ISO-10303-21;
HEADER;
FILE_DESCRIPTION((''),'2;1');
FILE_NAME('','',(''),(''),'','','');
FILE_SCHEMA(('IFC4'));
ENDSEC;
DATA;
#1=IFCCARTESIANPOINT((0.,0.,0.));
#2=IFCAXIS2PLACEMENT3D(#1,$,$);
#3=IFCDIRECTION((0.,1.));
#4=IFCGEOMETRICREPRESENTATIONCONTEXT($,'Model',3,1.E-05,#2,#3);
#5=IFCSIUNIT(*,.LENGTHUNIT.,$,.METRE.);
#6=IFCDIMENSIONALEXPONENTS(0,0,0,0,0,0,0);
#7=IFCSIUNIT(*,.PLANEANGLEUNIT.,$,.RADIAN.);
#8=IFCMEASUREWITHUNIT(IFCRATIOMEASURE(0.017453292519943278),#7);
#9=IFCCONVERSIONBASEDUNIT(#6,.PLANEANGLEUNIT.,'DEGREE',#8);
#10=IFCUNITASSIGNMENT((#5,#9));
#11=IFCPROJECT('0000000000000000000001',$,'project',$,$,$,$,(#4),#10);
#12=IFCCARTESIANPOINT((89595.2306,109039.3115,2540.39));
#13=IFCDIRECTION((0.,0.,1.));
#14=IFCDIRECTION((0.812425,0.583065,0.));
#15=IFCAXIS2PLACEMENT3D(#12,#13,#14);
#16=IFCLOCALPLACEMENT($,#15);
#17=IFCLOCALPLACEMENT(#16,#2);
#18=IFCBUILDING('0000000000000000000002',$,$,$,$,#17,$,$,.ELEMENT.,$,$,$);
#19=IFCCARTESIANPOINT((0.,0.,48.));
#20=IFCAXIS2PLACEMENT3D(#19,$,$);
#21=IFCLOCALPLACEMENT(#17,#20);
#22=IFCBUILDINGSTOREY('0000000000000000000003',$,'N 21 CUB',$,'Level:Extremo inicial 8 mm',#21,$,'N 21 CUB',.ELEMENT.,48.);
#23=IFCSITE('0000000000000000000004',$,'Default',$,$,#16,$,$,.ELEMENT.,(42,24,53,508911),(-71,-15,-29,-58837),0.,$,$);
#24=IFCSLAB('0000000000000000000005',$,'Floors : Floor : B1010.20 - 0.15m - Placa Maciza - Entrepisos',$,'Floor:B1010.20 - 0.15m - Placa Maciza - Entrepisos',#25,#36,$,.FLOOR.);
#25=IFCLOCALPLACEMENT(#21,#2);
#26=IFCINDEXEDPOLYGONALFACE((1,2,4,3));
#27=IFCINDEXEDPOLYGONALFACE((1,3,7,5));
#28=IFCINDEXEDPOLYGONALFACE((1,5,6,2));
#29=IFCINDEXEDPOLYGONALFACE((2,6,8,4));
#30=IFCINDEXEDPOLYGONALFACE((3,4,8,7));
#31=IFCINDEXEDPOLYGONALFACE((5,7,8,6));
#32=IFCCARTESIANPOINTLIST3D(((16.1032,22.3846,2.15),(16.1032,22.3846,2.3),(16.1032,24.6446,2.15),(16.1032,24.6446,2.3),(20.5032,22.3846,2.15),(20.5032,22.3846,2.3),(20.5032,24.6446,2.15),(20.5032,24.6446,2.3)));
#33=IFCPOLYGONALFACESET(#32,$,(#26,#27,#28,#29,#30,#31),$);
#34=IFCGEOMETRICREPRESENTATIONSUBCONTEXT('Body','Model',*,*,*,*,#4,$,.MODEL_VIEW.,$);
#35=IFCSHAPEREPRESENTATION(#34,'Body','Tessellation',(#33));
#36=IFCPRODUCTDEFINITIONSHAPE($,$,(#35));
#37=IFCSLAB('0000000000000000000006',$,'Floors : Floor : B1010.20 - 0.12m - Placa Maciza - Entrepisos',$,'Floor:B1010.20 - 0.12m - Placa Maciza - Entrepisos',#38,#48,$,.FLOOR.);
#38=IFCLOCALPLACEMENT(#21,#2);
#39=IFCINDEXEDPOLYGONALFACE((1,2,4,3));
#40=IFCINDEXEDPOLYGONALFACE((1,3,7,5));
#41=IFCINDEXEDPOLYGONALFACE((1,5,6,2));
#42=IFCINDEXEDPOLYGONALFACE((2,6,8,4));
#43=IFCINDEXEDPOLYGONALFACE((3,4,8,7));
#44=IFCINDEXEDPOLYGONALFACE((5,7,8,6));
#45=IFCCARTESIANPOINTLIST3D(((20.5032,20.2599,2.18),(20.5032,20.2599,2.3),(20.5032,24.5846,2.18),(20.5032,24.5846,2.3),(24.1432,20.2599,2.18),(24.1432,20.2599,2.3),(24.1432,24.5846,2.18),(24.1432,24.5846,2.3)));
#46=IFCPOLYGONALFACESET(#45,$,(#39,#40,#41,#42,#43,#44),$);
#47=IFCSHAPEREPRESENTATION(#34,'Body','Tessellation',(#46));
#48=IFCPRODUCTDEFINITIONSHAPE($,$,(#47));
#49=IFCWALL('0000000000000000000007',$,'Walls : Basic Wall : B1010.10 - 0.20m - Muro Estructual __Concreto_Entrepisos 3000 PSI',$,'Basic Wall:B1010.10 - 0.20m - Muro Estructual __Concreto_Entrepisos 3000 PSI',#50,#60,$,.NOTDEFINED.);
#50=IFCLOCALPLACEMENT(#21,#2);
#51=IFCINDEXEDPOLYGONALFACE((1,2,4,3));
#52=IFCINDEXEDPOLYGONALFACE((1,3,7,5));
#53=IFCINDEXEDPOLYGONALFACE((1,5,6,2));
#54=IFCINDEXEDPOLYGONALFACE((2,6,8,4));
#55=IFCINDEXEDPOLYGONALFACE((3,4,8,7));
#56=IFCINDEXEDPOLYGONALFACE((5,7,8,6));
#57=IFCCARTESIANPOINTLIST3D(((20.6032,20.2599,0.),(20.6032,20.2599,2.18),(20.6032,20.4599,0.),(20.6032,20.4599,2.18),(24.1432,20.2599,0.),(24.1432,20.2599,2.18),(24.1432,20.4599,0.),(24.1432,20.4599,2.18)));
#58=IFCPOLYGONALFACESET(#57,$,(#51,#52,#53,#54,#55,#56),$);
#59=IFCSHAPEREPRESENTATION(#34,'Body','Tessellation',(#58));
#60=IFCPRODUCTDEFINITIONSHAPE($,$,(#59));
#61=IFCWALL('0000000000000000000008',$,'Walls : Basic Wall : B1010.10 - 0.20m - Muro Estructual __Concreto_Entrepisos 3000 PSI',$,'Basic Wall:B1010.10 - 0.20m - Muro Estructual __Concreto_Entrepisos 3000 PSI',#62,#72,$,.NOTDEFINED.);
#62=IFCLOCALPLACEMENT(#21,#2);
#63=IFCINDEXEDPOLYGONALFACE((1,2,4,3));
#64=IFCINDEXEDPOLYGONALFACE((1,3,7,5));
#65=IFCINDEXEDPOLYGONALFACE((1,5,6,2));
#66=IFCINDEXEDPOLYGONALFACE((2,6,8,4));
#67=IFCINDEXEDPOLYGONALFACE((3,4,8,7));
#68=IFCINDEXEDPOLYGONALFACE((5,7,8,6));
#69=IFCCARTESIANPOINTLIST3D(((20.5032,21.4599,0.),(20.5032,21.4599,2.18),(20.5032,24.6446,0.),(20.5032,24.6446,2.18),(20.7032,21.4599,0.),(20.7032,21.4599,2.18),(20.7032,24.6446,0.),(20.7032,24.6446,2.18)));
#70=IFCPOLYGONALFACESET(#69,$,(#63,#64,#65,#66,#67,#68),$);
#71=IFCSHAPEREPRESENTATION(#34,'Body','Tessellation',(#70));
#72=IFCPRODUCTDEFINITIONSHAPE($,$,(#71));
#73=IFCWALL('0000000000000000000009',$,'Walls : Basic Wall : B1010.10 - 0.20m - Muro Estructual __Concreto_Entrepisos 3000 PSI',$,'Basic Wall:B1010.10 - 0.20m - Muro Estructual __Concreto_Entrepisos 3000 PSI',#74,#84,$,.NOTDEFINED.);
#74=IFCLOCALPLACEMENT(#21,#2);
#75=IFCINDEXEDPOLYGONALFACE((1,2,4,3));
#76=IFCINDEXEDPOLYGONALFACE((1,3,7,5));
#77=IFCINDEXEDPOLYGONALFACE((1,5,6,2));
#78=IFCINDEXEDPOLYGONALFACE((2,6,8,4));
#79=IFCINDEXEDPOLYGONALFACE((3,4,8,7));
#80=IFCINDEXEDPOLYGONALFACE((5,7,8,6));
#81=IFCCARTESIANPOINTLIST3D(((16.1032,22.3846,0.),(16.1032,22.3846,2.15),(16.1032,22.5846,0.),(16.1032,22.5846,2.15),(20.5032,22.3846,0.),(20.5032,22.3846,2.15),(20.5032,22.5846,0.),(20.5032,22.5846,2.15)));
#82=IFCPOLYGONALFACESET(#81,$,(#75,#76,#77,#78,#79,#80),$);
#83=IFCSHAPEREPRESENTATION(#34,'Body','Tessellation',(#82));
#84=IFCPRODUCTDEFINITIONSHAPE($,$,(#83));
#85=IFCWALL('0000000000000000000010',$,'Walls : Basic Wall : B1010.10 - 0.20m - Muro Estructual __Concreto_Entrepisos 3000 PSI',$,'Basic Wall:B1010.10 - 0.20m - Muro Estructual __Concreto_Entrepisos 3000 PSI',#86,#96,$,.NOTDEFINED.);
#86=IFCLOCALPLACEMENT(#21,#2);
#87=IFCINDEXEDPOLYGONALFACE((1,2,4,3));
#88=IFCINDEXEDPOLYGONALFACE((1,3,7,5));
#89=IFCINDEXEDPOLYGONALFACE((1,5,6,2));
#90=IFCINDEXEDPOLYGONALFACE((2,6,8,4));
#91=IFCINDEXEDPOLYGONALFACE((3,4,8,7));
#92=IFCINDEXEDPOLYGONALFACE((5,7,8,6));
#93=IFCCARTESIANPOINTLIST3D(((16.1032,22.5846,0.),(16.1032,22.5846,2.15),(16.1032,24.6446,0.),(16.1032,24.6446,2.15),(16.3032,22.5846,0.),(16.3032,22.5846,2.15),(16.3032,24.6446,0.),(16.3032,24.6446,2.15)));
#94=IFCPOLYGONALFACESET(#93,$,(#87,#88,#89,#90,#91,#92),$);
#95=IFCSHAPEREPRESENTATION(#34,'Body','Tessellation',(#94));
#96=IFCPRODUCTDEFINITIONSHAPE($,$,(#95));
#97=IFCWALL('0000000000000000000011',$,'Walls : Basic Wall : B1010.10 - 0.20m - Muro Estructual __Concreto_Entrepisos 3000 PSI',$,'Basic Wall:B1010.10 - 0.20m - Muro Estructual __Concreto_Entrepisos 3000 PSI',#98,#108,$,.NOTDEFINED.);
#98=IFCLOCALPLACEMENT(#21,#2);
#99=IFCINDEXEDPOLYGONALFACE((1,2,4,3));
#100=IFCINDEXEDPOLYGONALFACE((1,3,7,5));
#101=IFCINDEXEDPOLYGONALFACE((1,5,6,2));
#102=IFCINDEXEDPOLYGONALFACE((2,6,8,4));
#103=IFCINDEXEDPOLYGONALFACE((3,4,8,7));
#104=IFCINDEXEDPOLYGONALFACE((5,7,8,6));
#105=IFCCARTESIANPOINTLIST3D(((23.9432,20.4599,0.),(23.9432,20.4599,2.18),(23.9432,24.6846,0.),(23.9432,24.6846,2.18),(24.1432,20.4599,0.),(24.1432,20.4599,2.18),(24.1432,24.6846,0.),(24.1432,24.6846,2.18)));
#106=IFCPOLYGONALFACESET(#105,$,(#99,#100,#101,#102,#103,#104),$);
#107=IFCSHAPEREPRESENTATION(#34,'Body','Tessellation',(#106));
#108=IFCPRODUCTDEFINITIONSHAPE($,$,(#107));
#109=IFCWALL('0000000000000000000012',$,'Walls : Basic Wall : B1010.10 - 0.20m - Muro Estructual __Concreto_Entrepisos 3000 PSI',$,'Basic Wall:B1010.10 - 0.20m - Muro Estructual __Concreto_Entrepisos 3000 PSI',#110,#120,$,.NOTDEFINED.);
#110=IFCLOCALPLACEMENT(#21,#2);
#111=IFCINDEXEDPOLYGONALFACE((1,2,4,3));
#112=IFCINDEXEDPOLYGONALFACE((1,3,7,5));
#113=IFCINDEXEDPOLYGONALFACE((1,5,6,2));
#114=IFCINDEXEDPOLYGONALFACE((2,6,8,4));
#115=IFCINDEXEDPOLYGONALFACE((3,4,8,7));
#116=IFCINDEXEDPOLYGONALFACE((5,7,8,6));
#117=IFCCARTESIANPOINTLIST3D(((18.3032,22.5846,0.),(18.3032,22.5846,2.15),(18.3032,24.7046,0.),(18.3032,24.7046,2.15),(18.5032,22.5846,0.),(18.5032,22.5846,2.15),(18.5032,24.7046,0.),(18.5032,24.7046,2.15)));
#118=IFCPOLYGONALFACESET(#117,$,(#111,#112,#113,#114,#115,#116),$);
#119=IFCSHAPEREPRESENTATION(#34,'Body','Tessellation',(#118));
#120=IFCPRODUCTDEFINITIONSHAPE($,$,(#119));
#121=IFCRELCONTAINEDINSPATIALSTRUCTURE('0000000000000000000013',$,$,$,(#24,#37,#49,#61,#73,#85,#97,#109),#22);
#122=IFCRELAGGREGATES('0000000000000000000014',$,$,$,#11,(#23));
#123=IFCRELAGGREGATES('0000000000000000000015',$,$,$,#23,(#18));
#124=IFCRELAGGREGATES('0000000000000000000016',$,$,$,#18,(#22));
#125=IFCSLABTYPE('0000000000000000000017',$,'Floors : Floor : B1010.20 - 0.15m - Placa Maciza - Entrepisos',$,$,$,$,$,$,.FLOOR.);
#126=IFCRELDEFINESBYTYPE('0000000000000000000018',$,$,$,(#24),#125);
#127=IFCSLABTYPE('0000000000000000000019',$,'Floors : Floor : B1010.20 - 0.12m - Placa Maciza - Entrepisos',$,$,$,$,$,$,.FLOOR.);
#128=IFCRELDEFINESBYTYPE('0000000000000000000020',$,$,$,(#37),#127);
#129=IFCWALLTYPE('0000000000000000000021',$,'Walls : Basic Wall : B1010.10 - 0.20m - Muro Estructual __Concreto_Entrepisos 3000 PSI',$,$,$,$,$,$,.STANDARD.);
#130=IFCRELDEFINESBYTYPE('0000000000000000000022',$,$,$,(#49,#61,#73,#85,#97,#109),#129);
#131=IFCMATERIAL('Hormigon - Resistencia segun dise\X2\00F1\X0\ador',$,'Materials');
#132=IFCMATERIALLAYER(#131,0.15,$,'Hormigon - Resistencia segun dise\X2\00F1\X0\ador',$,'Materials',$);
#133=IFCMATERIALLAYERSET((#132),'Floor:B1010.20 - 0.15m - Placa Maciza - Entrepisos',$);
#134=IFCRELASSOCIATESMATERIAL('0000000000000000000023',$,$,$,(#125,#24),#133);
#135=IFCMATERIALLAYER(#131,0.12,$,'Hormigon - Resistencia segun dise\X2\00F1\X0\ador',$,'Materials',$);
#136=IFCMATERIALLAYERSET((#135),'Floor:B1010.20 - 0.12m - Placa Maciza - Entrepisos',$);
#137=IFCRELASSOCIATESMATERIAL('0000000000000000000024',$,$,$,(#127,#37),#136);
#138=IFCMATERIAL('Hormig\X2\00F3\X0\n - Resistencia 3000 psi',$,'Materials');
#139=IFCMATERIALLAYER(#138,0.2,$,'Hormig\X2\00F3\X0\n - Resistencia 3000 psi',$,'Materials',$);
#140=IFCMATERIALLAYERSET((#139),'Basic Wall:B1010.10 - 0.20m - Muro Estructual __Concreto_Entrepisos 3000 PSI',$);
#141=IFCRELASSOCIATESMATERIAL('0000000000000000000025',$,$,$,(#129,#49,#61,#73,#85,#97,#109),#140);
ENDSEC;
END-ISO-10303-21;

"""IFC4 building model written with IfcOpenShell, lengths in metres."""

from ifc_helpers import new_model, entity, si_unit, converted_unit, direction, frame, frame_2d, origin, origin_2d_with_axis, place, context, subcontext, project, spatial, rectangle, extrude, material, layer, layer_set, layer_usage, type_object, element, save


model = new_model("IFC4")

# Units and contexts
model_context = context("Model", 3, precision=1e-05, world=origin(), true_north=direction((0.0, 1.0)))
body_context = subcontext(model_context, "Body", "Model", "MODEL_VIEW")
ifc_project = project(units=[si_unit("LENGTHUNIT", "METRE"), converted_unit("PLANEANGLEUNIT", "DEGREE", entity("IfcRatioMeasure", 0.017453292519943278), si_unit("PLANEANGLEUNIT", "RADIAN"), dimensions=[0, 0, 0, 0, 0, 0, 0])], contexts=[model_context])

# Site, building, storey
site_placement = place(None, frame((89595.2306, 109039.3115, 2540.39), z_axis=(0.0, 0.0, 1.0), x_axis=(0.812425, 0.583065, 0.0)))
site = spatial("IfcSite", under=ifc_project, at=site_placement, Name="Default", CompositionType="ELEMENT", RefLatitude=(42, 24, 53, 508911), RefLongitude=(-71, -15, -29, -58837), RefElevation=0.0)
building_placement = place(site_placement, origin())
building = spatial("IfcBuilding", under=site, at=building_placement, CompositionType="ELEMENT")
storey_placement = place(building_placement, frame((0.0, 0.0, 48.0)))
storey = spatial("IfcBuildingStorey", under=building, at=storey_placement, Name="N 21 CUB", ObjectType="Level:Extremo inicial 8 mm", LongName="N 21 CUB", CompositionType="ELEMENT", Elevation=48.0)

# Shared definitions
ifc_material_1 = material(Name="Hormigon - Resistencia segun diseñador", Category="Materials")
ifc_layer_1 = layer(ifc_material_1, 0.12, Name="Hormigon - Resistencia segun diseñador", Category="Materials")
ifc_layer_set_1 = layer_set([ifc_layer_1], Name="Floor:B1010.20 - 0.12m - Placa Maciza - Entrepisos")

# Slabs
ifc_layer_2 = layer(ifc_material_1, 0.15, Name="Hormigon - Resistencia segun diseñador", Category="Materials")
ifc_layer_set_2 = layer_set([ifc_layer_2], Name="Floor:B1010.20 - 0.15m - Placa Maciza - Entrepisos")
ifc_layer_usage_1 = layer_usage(ifc_layer_set_2, "AXIS3", "POSITIVE", 0.0)
slab_type_1 = type_object("IfcSlabType", Name="Floors : Floor : B1010.20 - 0.15m - Placa Maciza - Entrepisos", PredefinedType="FLOOR", material=ifc_layer_set_2)
slab_1_placement = place(storey_placement, origin())
element("IfcSlab", 1, at=slab_1_placement, inside=storey, type_object=slab_type_1, material=ifc_layer_usage_1, Name="Floors : Floor : B1010.20 - 0.15m - Placa Maciza - Entrepisos", ObjectType="Floor:B1010.20 - 0.15m - Placa Maciza - Entrepisos", PredefinedType="FLOOR", context=body_context, shape_type="SweptSolid", body=[
    extrude(rectangle(XDim=2.26, YDim=4.4, at=origin_2d_with_axis()), frame((18.3032, 23.5146, 2.3), z_axis=(0.0, 0.0, -1.0), x_axis=(0.0, 1.0, 0.0)), (0.0, 0.0, 1.0), 0.15),
])
ifc_layer_usage_2 = layer_usage(ifc_layer_set_1, "AXIS3", "POSITIVE", 0.0)
slab_type_2 = type_object("IfcSlabType", Name="Floors : Floor : B1010.20 - 0.12m - Placa Maciza - Entrepisos", PredefinedType="FLOOR", material=ifc_layer_set_1)
slab_2_placement = place(storey_placement, origin())
element("IfcSlab", 2, at=slab_2_placement, inside=storey, type_object=slab_type_2, material=ifc_layer_usage_2, Name="Floors : Floor : B1010.20 - 0.12m - Placa Maciza - Entrepisos", ObjectType="Floor:B1010.20 - 0.12m - Placa Maciza - Entrepisos", PredefinedType="FLOOR", context=body_context, shape_type="SweptSolid", body=[
    extrude(rectangle(XDim=4.3247, YDim=3.64, at=frame_2d((0.0, 0.0), x_axis=(1.0, 0.0))), frame((22.3232, 22.4223, 2.3), z_axis=(0.0, 0.0, -1.0), x_axis=(0.0, 1.0, 0.0)), (0.0, 0.0, 1.0), 0.12),
])

# Walls
ifc_material_2 = material(Name="Hormigón - Resistencia 3000 psi", Category="Materials")
ifc_layer_3 = layer(ifc_material_2, 0.2, Name="Hormigón - Resistencia 3000 psi", Category="Materials")
ifc_layer_set_3 = layer_set([ifc_layer_3], Name="Basic Wall:B1010.10 - 0.20m - Muro Estructual __Concreto_Entrepisos 3000 PSI")
ifc_layer_usage_3 = layer_usage(ifc_layer_set_3, "AXIS2", "POSITIVE", -0.1)
wall_type = type_object("IfcWallType", Name="Walls : Basic Wall : B1010.10 - 0.20m - Muro Estructual __Concreto_Entrepisos 3000 PSI", PredefinedType="STANDARD", material=ifc_layer_set_3)
wall_1_placement = place(storey_placement, frame((20.6032, 20.3599, 0.0)))
element("IfcWall", 3, at=wall_1_placement, inside=storey, type_object=wall_type, material=ifc_layer_usage_3, Name="Walls : Basic Wall : B1010.10 - 0.20m - Muro Estructual __Concreto_Entrepisos 3000 PSI", ObjectType="Basic Wall:B1010.10 - 0.20m - Muro Estructual __Concreto_Entrepisos 3000 PSI", PredefinedType="NOTDEFINED", context=body_context, shape_type="SweptSolid", body=[
    extrude(rectangle(XDim=3.54, YDim=0.2, at=frame_2d((1.77, 0.0), x_axis=(-1.0, 0.0))), origin(), (0.0, 0.0, 1.0), 2.18),
])
ifc_layer_usage_4 = layer_usage(ifc_layer_set_3, "AXIS2", "POSITIVE", -0.1)
wall_2_placement = place(storey_placement, frame((20.6032, 24.6446, 0.0), z_axis=(0.0, 0.0, 1.0), x_axis=(0.0, -1.0, 0.0)))
element("IfcWall", 4, at=wall_2_placement, inside=storey, type_object=wall_type, material=ifc_layer_usage_4, Name="Walls : Basic Wall : B1010.10 - 0.20m - Muro Estructual __Concreto_Entrepisos 3000 PSI", ObjectType="Basic Wall:B1010.10 - 0.20m - Muro Estructual __Concreto_Entrepisos 3000 PSI", PredefinedType="NOTDEFINED", context=body_context, shape_type="SweptSolid", body=[
    extrude(rectangle(XDim=3.1847, YDim=0.2, at=frame_2d((1.5924, 0.0), x_axis=(-1.0, 0.0))), origin(), (0.0, 0.0, 1.0), 2.18),
])
ifc_layer_usage_5 = layer_usage(ifc_layer_set_3, "AXIS2", "POSITIVE", -0.1)
wall_3_placement = place(storey_placement, frame((20.5032, 22.4846, 0.0), z_axis=(0.0, 0.0, 1.0), x_axis=(-1.0, 0.0, 0.0)))
element("IfcWall", 5, at=wall_3_placement, inside=storey, type_object=wall_type, material=ifc_layer_usage_5, Name="Walls : Basic Wall : B1010.10 - 0.20m - Muro Estructual __Concreto_Entrepisos 3000 PSI", ObjectType="Basic Wall:B1010.10 - 0.20m - Muro Estructual __Concreto_Entrepisos 3000 PSI", PredefinedType="NOTDEFINED", context=body_context, shape_type="SweptSolid", body=[
    extrude(rectangle(XDim=4.4, YDim=0.2, at=frame_2d((2.2, 0.0), x_axis=(-1.0, 0.0))), origin(), (0.0, 0.0, 1.0), 2.15),
])
ifc_layer_usage_6 = layer_usage(ifc_layer_set_3, "AXIS2", "POSITIVE", -0.1)
wall_4_placement = place(storey_placement, frame((16.2032, 22.5846, 0.0), z_axis=(0.0, 0.0, 1.0), x_axis=(0.0, 1.0, 0.0)))
element("IfcWall", 6, at=wall_4_placement, inside=storey, type_object=wall_type, material=ifc_layer_usage_6, Name="Walls : Basic Wall : B1010.10 - 0.20m - Muro Estructual __Concreto_Entrepisos 3000 PSI", ObjectType="Basic Wall:B1010.10 - 0.20m - Muro Estructual __Concreto_Entrepisos 3000 PSI", PredefinedType="NOTDEFINED", context=body_context, shape_type="SweptSolid", body=[
    extrude(rectangle(XDim=2.06, YDim=0.2, at=frame_2d((1.03, 0.0), x_axis=(-1.0, 0.0))), origin(), (0.0, 0.0, 1.0), 2.15),
])
ifc_layer_usage_7 = layer_usage(ifc_layer_set_3, "AXIS2", "NEGATIVE", 0.1)
wall_5_placement = place(storey_placement, frame((24.0432, 20.4599, 0.0), z_axis=(0.0, 0.0, 1.0), x_axis=(0.0, 1.0, 0.0)))
element("IfcWall", 7, at=wall_5_placement, inside=storey, type_object=wall_type, material=ifc_layer_usage_7, Name="Walls : Basic Wall : B1010.10 - 0.20m - Muro Estructual __Concreto_Entrepisos 3000 PSI", ObjectType="Basic Wall:B1010.10 - 0.20m - Muro Estructual __Concreto_Entrepisos 3000 PSI", PredefinedType="NOTDEFINED", context=body_context, shape_type="SweptSolid", body=[
    extrude(rectangle(XDim=4.2247, YDim=0.2, at=frame_2d((2.1124, 0.0), x_axis=(-1.0, 0.0))), origin(), (0.0, 0.0, 1.0), 2.18),
])
ifc_layer_usage_8 = layer_usage(ifc_layer_set_3, "AXIS2", "NEGATIVE", 0.1)
wall_6_placement = place(storey_placement, frame((18.4032, 24.7046, 0.0), z_axis=(0.0, 0.0, 1.0), x_axis=(0.0, -1.0, 0.0)))
element("IfcWall", 8, at=wall_6_placement, inside=storey, type_object=wall_type, material=ifc_layer_usage_8, Name="Walls : Basic Wall : B1010.10 - 0.20m - Muro Estructual __Concreto_Entrepisos 3000 PSI", ObjectType="Basic Wall:B1010.10 - 0.20m - Muro Estructual __Concreto_Entrepisos 3000 PSI", PredefinedType="NOTDEFINED", context=body_context, shape_type="SweptSolid", body=[
    extrude(rectangle(XDim=2.12, YDim=0.2, at=frame_2d((1.06, 0.0), x_axis=(-1.0, 0.0))), origin(), (0.0, 0.0, 1.0), 2.15),
])

save(model, "model.ifc")
